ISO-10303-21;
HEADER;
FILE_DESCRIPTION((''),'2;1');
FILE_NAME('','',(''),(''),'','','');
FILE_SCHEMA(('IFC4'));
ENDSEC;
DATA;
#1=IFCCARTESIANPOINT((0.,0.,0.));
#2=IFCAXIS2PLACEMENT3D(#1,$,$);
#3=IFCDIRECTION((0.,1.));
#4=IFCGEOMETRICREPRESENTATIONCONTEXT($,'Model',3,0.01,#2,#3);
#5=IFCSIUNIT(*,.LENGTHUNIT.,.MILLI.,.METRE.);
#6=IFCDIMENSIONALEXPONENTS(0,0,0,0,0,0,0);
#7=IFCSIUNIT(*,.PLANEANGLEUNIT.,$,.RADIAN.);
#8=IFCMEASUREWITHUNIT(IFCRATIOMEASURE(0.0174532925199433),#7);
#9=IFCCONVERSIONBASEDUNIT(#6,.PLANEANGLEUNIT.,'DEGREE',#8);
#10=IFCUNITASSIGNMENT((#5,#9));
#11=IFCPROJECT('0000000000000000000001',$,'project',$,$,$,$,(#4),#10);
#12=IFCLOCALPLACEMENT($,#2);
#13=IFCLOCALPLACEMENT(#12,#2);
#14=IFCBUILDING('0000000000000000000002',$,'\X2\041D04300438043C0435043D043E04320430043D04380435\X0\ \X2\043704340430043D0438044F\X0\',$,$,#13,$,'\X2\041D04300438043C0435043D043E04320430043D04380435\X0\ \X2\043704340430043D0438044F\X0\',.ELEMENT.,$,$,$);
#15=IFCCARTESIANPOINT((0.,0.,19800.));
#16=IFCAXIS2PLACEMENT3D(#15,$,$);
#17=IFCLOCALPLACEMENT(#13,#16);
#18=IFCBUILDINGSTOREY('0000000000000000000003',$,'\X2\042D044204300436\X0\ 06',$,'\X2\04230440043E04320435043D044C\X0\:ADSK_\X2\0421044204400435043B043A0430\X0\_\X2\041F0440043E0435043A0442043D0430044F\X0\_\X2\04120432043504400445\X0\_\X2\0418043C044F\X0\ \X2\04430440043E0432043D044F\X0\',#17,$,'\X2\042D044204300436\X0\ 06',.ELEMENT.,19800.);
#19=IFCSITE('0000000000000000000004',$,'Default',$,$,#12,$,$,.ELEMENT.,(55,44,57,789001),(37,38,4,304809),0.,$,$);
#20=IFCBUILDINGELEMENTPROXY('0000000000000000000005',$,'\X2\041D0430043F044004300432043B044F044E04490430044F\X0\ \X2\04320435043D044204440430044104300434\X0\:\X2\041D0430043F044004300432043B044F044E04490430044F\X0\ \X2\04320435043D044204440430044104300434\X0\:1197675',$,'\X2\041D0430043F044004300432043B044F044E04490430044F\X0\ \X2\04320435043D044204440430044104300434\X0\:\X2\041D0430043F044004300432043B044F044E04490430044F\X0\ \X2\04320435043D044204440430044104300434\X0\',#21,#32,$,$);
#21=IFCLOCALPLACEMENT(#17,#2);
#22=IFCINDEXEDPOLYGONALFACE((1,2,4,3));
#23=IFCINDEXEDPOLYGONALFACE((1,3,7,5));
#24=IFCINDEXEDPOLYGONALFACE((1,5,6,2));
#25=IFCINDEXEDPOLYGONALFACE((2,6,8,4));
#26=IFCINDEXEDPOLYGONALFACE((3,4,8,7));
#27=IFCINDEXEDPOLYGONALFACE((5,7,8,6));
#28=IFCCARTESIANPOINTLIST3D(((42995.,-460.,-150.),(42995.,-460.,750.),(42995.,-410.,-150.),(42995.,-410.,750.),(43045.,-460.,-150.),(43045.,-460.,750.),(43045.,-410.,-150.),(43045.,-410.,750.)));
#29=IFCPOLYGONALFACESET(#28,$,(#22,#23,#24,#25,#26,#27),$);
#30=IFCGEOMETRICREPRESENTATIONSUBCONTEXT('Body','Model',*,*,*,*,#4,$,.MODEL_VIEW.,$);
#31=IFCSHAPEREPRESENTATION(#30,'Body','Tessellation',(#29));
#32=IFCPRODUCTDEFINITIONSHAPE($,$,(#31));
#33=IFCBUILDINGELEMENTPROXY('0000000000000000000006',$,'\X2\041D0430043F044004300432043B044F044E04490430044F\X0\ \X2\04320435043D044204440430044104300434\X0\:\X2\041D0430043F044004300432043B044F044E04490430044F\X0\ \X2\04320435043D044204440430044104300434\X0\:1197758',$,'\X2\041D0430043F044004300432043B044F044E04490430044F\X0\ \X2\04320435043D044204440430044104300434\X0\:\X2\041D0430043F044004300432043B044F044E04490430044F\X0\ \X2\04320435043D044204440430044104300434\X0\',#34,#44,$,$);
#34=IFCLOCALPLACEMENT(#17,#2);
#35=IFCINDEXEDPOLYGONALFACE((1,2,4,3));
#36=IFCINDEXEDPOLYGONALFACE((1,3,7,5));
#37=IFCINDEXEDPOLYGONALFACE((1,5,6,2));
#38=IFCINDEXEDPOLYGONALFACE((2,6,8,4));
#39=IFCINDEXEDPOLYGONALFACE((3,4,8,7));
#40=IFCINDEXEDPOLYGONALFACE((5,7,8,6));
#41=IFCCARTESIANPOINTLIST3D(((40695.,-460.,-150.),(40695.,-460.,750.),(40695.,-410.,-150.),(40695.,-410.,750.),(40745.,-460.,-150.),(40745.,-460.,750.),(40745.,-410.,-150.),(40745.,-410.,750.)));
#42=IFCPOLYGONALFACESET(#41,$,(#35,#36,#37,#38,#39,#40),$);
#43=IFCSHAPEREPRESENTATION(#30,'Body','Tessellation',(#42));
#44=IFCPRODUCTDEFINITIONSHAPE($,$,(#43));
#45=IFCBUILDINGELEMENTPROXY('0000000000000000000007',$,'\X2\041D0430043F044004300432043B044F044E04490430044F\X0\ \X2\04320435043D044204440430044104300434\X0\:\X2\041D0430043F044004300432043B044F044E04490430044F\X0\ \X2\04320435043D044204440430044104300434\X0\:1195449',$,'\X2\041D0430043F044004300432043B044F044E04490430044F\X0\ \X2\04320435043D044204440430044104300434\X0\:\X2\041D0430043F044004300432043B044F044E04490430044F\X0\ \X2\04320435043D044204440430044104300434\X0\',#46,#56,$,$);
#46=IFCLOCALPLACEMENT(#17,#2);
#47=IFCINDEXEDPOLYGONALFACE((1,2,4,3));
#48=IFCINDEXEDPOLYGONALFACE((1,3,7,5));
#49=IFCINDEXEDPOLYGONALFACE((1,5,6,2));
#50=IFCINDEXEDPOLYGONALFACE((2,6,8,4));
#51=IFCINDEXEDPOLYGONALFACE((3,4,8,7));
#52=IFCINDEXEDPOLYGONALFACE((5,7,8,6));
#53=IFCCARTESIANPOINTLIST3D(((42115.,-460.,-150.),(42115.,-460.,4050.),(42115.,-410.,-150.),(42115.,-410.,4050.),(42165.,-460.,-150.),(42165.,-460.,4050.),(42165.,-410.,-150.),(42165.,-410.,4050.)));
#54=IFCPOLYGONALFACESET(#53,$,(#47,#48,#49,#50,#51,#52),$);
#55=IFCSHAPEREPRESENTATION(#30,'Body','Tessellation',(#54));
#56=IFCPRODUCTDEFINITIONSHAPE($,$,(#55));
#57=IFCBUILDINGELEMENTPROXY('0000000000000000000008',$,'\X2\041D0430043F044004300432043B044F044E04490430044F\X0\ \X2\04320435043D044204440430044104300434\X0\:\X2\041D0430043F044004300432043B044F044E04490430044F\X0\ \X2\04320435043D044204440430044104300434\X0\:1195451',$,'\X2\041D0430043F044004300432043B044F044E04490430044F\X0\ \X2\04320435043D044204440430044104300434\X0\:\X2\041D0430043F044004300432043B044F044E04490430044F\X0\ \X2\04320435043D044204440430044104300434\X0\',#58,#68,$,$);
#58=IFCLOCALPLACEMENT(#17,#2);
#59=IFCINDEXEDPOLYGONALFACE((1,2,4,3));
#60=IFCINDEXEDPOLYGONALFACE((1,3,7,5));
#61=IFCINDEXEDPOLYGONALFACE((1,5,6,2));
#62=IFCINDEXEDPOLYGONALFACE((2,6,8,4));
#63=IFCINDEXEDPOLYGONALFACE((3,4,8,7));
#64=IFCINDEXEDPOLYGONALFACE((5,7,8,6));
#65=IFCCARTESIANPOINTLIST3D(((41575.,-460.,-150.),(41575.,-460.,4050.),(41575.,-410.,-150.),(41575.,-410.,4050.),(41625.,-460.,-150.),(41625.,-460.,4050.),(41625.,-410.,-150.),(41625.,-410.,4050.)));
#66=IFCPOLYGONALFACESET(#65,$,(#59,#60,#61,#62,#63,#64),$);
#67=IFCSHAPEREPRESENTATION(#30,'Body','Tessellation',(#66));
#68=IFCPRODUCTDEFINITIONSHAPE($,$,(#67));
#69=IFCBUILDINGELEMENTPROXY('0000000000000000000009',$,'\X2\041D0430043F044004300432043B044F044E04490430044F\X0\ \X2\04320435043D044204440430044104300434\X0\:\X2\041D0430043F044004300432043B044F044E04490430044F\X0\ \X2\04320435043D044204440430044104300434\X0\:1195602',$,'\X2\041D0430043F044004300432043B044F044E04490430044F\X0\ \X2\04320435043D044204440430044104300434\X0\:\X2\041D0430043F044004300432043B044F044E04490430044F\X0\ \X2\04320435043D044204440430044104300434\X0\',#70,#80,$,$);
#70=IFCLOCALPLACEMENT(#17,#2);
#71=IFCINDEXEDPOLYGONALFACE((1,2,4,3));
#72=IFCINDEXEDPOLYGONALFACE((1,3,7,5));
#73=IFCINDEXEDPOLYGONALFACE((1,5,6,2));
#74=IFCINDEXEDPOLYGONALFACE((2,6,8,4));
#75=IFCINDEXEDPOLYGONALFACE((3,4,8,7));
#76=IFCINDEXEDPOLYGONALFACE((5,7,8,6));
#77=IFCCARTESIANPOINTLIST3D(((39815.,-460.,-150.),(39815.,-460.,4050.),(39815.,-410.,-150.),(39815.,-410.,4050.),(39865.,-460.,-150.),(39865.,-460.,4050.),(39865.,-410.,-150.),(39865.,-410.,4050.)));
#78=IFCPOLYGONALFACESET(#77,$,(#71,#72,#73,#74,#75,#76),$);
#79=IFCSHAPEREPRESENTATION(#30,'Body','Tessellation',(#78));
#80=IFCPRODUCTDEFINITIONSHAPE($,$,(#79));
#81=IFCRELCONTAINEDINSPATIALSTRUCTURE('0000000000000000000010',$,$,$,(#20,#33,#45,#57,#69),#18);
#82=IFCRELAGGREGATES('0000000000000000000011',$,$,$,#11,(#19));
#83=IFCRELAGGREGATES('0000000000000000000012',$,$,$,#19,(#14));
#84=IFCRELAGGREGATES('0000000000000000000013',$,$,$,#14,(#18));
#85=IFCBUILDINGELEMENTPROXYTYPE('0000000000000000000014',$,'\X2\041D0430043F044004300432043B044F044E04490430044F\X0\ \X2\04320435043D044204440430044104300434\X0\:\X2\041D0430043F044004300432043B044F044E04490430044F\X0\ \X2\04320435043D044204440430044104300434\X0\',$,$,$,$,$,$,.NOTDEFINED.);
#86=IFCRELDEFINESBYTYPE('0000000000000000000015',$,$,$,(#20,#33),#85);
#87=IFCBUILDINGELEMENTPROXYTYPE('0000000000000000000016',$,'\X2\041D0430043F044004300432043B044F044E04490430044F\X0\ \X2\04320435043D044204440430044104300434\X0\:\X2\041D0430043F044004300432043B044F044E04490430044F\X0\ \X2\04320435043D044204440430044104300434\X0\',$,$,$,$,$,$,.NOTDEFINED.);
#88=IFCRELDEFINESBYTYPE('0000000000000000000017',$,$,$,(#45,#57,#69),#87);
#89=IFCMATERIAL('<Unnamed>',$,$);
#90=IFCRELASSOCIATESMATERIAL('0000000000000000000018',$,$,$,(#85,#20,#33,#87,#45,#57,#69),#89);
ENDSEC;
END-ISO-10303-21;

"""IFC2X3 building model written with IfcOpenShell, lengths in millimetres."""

from ifc_helpers import new_model, entity, si_unit, converted_unit, direction, frame, origin, origin_2d_with_axis, place, context, subcontext, project, spatial, rectangle, extrude, source, transform, mapped, material, type_object, type_shapes, element, save


model = new_model("IFC2X3")

# Units and contexts
model_context = context("Model", 3, precision=0.01, world=origin(), true_north=direction((0.0, 1.0)))
body_context = subcontext(model_context, "Body", "Model", "MODEL_VIEW")
ifc_project = project(units=[si_unit("LENGTHUNIT", "METRE", prefix="MILLI"), converted_unit("PLANEANGLEUNIT", "DEGREE", entity("IfcRatioMeasure", 0.0174532925199433), si_unit("PLANEANGLEUNIT", "RADIAN"), dimensions=[0, 0, 0, 0, 0, 0, 0])], contexts=[model_context])

# Site, building, storey
site_placement = place(None, origin())
site = spatial("IfcSite", under=ifc_project, at=site_placement, Name="Default", CompositionType="ELEMENT", RefLatitude=(55, 44, 57, 789001), RefLongitude=(37, 38, 4, 304809), RefElevation=0.0)
building_placement = place(site_placement, origin())
building = spatial("IfcBuilding", under=site, at=building_placement, Name="Наименование здания", LongName="Наименование здания", CompositionType="ELEMENT")
storey_placement = place(building_placement, frame((0.0, 0.0, 19800.0)))
storey = spatial("IfcBuildingStorey", under=building, at=storey_placement, Name="Этаж 06", ObjectType="Уровень:ADSK_Стрелка_Проектная_Вверх_Имя уровня", LongName="Этаж 06", CompositionType="ELEMENT", Elevation=19800.0)

# Building element proxies
ifc_material_1 = material(Name="<Unnamed>")
building_element_proxy_type_1 = type_object("IfcBuildingElementProxyType", Name="Направляющая вентфасад:Направляющая вентфасад", PredefinedType="NOTDEFINED", material=ifc_material_1)
shared_shape_1 = source(origin(), body_context, "Body", "SweptSolid", [
    extrude(rectangle(XDim=50.0, YDim=50.0, at=origin_2d_with_axis()), frame((25.0, -25.0, 0.0), z_axis=(0.0, 0.0, 1.0), x_axis=(-1.0, 0.0, 0.0)), (0.0, 0.0, 1.0), 900.0),
])
type_shapes(building_element_proxy_type_1, [shared_shape_1])
for number, where, name in (
    (1, (42995.0, -410.0, -150.0), "Направляющая вентфасад:Направляющая вентфасад:1197675"),
    (2, (40695.0, -410.0, -150.0), "Направляющая вентфасад:Направляющая вентфасад:1197758"),
):
    element("IfcBuildingElementProxy", number, at=place(storey_placement, frame(where)), inside=storey, type_object=building_element_proxy_type_1, material=ifc_material_1, Name=name, ObjectType="Направляющая вентфасад:Направляющая вентфасад", context=body_context, shape_type="MappedRepresentation", body=[
        mapped(shared_shape_1, transform((0.0, 0.0, 0.0), scale=1.0)),
    ])
building_element_proxy_type_2 = type_object("IfcBuildingElementProxyType", Name="Направляющая вентфасад:Направляющая вентфасад", PredefinedType="NOTDEFINED", material=ifc_material_1)
shared_shape_2 = source(origin(), body_context, "Body", "SweptSolid", [
    extrude(rectangle(XDim=50.0, YDim=50.0, at=origin_2d_with_axis()), frame((25.0, -25.0, 0.0), z_axis=(0.0, 0.0, 1.0), x_axis=(-1.0, 0.0, 0.0)), (0.0, 0.0, 1.0), 4200.0),
])
type_shapes(building_element_proxy_type_2, [shared_shape_2])
for number, where, name in (
    (3, (42115.0, -410.0, -150.0), "Направляющая вентфасад:Направляющая вентфасад:1195449"),
    (4, (41575.0, -410.0, -150.0), "Направляющая вентфасад:Направляющая вентфасад:1195451"),
    (5, (39815.0, -410.0, -150.0), "Направляющая вентфасад:Направляющая вентфасад:1195602"),
):
    element("IfcBuildingElementProxy", number, at=place(storey_placement, frame(where)), inside=storey, type_object=building_element_proxy_type_2, material=ifc_material_1, Name=name, ObjectType="Направляющая вентфасад:Направляющая вентфасад", context=body_context, shape_type="MappedRepresentation", body=[
        mapped(shared_shape_2, transform((0.0, 0.0, 0.0), scale=1.0)),
    ])

save(model, "model.ifc")
